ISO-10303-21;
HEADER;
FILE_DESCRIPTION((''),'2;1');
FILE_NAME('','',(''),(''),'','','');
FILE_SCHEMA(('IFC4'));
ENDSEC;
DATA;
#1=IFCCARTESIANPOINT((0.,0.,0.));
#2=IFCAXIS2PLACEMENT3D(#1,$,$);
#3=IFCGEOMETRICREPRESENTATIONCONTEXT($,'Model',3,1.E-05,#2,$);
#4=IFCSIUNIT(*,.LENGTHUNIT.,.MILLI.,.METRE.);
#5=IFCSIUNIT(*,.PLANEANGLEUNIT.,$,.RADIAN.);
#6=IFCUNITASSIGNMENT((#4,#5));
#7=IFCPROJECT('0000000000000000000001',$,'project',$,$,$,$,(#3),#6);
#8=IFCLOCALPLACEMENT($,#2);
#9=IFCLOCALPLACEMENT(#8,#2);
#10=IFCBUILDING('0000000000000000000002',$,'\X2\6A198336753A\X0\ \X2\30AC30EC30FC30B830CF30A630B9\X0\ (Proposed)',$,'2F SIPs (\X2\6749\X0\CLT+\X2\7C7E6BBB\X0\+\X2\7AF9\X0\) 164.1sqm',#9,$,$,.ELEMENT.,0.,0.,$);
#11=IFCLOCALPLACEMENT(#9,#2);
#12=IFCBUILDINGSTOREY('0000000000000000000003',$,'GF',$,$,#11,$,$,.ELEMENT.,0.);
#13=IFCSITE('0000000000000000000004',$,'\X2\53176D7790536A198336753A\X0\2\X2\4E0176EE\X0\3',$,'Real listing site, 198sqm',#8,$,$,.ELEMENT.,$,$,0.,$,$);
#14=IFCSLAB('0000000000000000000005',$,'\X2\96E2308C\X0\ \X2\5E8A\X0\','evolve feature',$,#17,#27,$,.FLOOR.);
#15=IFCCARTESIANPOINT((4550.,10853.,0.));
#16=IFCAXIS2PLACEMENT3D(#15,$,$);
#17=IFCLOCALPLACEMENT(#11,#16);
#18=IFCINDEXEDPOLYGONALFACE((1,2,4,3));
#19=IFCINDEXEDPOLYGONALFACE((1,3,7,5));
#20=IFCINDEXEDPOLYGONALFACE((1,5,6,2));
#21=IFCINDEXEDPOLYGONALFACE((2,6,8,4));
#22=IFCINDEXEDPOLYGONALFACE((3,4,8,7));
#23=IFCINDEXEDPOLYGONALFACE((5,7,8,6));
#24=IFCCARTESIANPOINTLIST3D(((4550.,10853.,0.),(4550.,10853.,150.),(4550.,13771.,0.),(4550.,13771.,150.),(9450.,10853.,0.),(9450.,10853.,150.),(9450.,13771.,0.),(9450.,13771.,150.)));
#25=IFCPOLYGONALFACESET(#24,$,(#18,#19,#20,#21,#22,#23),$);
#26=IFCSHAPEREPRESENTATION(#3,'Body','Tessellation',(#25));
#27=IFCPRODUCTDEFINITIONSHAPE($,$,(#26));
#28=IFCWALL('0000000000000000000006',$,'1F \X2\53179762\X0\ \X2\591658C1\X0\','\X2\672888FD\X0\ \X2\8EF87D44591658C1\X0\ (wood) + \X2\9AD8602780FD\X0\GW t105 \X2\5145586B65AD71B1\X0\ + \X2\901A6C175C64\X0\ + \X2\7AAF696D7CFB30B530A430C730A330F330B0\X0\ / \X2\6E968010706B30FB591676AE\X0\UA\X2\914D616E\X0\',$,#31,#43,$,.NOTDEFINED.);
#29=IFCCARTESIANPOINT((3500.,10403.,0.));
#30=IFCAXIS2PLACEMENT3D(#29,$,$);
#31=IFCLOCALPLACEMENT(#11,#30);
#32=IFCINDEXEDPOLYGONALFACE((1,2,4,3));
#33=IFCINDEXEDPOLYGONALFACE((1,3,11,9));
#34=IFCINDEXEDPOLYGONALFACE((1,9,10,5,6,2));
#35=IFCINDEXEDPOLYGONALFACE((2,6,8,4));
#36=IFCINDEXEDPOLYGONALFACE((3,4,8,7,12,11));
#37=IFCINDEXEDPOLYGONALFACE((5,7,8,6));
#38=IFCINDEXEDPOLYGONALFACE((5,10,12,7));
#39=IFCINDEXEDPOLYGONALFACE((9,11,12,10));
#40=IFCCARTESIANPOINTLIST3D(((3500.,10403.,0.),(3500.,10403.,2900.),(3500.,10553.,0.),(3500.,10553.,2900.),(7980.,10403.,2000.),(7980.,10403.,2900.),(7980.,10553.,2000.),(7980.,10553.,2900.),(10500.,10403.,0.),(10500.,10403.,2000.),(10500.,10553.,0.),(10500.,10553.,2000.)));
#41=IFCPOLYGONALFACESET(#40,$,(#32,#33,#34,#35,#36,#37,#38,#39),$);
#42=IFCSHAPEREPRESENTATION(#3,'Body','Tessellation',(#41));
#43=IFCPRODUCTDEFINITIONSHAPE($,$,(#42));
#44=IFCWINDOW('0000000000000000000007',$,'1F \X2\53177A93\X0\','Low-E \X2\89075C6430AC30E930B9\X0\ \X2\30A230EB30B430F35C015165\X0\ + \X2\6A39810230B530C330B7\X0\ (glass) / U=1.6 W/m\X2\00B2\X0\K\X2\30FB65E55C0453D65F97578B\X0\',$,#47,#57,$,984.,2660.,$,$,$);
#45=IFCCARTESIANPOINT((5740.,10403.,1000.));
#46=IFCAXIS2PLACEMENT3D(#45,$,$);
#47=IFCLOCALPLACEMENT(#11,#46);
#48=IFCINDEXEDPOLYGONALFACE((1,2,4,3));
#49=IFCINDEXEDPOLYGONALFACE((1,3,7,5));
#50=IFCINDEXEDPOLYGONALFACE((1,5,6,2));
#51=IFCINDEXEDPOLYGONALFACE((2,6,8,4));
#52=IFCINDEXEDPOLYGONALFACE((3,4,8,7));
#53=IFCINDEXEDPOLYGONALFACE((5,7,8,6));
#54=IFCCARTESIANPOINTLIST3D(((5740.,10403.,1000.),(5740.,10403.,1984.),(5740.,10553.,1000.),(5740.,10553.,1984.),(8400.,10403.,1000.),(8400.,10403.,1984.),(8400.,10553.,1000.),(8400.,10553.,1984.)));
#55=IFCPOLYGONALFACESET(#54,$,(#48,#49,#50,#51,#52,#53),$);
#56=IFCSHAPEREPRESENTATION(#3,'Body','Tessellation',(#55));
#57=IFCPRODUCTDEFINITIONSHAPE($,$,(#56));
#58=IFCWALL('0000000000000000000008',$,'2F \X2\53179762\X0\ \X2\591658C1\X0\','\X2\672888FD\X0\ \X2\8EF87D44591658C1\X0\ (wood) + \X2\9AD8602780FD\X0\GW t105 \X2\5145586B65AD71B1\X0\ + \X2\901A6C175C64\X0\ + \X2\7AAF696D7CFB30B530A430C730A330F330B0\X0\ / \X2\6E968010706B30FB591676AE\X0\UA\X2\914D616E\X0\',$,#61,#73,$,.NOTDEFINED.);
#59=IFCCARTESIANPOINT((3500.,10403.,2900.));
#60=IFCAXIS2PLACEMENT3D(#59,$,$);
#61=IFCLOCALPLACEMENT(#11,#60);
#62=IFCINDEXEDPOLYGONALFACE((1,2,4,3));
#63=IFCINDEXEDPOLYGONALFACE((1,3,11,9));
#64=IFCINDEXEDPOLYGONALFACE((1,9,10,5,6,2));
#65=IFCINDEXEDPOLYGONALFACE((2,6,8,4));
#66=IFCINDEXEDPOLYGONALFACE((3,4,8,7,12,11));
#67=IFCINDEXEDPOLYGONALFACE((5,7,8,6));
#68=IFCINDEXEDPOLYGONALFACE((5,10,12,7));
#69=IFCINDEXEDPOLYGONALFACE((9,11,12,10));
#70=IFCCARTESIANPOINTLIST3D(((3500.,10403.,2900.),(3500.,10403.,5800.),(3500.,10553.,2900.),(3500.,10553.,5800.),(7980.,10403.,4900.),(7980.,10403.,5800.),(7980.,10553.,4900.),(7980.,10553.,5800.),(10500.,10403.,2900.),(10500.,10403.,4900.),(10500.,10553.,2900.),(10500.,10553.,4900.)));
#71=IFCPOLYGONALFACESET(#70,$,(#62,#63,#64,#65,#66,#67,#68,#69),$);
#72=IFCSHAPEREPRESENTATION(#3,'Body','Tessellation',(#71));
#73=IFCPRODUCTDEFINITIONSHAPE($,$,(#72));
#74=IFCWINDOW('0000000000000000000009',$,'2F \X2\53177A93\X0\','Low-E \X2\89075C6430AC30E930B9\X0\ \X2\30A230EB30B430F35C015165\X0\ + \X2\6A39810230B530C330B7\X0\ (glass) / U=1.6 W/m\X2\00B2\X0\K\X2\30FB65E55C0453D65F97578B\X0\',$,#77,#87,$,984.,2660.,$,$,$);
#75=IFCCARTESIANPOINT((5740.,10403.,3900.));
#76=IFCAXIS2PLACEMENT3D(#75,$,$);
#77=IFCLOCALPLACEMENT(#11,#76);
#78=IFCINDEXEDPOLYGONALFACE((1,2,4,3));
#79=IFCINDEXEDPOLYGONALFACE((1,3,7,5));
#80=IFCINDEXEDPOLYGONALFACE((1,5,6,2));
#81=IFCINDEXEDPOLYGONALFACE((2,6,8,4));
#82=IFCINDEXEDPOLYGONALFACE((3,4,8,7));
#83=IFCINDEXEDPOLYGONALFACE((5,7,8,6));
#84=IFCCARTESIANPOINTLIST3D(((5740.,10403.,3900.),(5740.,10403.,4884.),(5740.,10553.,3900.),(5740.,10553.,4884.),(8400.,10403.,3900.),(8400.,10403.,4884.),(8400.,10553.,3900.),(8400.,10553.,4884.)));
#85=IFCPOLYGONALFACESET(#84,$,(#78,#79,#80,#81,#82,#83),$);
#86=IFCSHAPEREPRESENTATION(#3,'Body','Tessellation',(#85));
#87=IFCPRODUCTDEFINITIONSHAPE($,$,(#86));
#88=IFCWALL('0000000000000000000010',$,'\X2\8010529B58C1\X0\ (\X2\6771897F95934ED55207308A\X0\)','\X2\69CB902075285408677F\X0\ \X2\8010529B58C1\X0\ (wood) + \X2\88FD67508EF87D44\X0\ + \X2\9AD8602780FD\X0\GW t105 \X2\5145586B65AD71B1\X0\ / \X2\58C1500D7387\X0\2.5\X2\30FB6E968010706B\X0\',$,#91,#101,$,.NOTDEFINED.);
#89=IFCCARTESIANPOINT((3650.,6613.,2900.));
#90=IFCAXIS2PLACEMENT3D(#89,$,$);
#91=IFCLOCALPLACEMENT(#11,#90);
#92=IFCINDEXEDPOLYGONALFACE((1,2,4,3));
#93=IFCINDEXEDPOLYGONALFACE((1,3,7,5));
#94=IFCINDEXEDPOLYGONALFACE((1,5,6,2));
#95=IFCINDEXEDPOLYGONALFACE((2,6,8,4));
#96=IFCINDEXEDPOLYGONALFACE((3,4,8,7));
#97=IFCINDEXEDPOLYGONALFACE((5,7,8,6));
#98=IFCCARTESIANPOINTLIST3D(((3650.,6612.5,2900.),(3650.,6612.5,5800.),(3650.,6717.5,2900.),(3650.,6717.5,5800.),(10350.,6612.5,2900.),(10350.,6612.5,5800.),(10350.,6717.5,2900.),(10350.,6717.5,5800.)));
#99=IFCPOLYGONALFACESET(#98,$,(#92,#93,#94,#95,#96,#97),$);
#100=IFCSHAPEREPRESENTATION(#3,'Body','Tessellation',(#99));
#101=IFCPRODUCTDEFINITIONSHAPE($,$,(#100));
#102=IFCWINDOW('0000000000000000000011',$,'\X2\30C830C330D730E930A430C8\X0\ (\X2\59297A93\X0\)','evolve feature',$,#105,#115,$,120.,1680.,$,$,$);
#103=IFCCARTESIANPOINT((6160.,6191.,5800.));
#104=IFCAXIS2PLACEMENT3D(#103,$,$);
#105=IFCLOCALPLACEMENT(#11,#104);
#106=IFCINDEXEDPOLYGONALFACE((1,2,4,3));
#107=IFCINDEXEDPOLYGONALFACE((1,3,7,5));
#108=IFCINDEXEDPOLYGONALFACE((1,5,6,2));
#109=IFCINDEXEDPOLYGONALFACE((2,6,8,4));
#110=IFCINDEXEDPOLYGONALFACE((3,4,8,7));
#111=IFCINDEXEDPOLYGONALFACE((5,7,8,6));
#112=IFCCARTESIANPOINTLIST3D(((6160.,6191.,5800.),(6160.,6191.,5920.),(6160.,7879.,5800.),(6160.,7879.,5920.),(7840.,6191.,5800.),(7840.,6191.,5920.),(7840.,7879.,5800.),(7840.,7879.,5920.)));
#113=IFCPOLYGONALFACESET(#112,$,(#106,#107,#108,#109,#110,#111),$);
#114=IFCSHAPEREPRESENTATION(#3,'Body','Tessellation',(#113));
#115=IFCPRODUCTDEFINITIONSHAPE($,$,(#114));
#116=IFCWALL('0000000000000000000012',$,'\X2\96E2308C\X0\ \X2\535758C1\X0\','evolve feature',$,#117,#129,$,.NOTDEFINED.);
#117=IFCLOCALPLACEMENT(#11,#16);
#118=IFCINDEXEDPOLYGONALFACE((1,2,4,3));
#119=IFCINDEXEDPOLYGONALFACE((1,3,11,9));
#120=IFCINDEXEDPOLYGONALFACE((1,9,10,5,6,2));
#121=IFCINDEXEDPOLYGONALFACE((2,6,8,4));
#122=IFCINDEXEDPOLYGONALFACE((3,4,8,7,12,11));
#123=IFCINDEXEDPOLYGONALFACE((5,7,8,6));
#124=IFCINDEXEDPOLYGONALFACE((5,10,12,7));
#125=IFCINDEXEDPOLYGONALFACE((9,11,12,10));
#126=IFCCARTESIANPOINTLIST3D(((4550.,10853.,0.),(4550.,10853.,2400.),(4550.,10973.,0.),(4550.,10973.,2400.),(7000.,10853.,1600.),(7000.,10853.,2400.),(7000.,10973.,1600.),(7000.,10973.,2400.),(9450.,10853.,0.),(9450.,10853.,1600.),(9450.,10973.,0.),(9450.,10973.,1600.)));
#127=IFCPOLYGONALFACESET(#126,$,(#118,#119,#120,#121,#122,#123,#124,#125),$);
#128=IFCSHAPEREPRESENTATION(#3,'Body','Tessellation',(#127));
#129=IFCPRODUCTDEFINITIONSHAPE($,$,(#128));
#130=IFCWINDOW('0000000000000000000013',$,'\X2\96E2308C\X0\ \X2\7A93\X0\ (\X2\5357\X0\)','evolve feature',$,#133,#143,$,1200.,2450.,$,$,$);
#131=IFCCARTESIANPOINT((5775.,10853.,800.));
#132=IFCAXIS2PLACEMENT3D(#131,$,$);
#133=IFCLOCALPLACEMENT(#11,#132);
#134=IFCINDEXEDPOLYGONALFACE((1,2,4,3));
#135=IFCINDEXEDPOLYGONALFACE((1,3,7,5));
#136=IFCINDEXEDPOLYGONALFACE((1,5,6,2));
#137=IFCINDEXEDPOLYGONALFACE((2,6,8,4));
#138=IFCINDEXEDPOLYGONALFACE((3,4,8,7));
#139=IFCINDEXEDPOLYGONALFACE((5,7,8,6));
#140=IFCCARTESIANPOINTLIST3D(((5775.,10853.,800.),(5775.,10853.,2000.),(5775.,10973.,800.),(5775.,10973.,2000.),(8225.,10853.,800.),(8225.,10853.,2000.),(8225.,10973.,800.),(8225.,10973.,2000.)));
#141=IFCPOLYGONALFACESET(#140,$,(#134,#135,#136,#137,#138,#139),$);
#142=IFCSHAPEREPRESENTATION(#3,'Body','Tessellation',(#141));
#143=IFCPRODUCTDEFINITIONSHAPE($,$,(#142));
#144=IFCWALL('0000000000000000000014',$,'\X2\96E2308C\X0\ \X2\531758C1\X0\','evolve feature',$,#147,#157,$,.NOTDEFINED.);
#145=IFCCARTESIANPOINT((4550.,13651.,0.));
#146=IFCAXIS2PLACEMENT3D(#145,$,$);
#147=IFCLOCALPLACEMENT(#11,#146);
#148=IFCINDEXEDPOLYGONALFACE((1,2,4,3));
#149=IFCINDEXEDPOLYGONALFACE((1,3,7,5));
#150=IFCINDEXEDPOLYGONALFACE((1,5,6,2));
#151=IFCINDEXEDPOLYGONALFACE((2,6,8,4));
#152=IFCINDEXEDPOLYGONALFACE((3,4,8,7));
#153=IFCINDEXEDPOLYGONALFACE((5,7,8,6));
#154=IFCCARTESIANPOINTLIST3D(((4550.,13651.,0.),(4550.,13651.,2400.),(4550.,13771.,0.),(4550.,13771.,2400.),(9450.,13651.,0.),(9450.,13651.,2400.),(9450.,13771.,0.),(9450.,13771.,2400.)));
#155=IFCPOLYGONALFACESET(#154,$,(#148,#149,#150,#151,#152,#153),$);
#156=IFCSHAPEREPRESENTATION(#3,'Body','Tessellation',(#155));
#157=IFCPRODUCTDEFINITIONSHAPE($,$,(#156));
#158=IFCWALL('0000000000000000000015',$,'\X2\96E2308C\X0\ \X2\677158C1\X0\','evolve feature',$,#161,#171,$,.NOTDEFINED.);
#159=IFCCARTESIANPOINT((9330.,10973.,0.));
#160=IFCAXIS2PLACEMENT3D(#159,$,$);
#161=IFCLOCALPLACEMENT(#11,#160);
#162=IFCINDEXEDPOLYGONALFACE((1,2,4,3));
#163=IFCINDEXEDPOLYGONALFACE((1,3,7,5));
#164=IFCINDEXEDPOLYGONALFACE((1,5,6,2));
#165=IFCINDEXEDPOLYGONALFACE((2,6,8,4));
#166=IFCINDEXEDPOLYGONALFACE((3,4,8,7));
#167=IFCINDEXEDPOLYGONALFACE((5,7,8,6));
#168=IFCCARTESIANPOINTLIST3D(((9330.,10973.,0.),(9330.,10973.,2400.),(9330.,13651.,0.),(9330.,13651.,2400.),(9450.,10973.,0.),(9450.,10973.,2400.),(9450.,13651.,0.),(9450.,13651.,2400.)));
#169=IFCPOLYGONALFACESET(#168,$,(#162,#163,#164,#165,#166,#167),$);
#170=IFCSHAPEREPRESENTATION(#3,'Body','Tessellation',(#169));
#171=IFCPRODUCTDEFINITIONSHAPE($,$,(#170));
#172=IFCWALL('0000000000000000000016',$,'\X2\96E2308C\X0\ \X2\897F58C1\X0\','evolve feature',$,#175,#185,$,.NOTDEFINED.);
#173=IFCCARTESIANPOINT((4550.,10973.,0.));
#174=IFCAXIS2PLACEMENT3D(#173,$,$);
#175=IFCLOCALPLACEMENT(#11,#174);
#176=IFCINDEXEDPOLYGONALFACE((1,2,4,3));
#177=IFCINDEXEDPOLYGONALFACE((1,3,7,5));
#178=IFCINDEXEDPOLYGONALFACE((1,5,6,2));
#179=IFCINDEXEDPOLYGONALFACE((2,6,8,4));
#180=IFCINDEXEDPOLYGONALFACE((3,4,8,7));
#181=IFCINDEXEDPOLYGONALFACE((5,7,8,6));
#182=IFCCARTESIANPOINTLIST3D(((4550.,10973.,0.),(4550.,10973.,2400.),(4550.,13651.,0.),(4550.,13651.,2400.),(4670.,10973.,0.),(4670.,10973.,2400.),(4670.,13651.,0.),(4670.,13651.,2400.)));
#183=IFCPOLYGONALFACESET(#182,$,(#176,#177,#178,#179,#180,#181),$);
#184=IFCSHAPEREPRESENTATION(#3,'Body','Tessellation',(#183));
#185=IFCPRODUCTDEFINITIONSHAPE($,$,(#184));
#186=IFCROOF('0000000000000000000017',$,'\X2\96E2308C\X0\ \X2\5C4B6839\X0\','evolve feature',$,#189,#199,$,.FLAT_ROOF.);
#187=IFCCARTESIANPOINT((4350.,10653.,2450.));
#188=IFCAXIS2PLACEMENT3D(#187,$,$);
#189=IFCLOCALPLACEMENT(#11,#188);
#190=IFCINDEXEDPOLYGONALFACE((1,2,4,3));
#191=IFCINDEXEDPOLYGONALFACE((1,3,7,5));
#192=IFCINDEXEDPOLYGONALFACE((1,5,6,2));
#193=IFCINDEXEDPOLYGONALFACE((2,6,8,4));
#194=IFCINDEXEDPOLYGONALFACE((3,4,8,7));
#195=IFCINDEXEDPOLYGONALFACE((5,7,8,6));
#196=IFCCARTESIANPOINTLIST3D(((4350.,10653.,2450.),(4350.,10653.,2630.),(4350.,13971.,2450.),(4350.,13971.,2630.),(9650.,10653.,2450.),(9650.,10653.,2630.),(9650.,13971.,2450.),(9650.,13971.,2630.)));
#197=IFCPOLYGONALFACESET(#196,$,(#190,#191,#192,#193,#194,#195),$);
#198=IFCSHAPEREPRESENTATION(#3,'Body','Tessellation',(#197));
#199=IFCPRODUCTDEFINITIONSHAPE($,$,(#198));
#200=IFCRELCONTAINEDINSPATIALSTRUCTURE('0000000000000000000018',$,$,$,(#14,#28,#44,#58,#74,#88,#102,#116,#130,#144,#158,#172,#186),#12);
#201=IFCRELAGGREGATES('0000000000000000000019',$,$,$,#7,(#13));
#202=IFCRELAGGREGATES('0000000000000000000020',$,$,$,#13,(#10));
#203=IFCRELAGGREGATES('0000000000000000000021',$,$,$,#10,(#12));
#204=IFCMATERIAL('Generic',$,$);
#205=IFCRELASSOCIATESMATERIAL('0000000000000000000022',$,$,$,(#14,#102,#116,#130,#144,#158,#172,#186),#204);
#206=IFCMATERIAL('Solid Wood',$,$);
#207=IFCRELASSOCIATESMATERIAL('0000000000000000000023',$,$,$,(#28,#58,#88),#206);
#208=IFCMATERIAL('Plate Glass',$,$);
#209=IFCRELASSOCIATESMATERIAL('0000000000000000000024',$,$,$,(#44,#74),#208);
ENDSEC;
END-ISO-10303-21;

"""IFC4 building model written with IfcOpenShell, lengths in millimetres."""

from ifc_helpers import new_model, si_unit, frame, frame_2d, origin, place, context, project, spatial, rectangle, extrude, material, element, fill, save


model = new_model("IFC4")

# Units and contexts
model_context = context("Model", 3, precision=1e-05, world=origin())
ifc_project = project(units=[si_unit("LENGTHUNIT", "METRE", prefix="MILLI"), si_unit("PLANEANGLEUNIT", "RADIAN")], contexts=[model_context])

# Site, building, storey
site_placement = place(None, origin())
site = spatial("IfcSite", under=ifc_project, at=site_placement, Name="北海道標茶町2丁目3", ObjectType="Real listing site, 198sqm", CompositionType="ELEMENT", RefElevation=0.0)
building_placement = place(site_placement, origin())
building = spatial("IfcBuilding", under=site, at=building_placement, Name="標茶町 ガレージハウス (Proposed)", ObjectType="2F SIPs (杉CLT+籾殻+竹) 164.1sqm", CompositionType="ELEMENT", ElevationOfRefHeight=0.0, ElevationOfTerrain=0.0)
storey_placement = place(building_placement, origin())
storey = spatial("IfcBuildingStorey", under=building, at=storey_placement, Name="GF", CompositionType="ELEMENT", Elevation=0.0)

# Slab
ifc_material_1 = material(Name="Generic")
slab_placement = place(storey_placement, frame((4550.0, 10853.0, 0.0)))
element("IfcSlab", 1, at=slab_placement, inside=storey, material=ifc_material_1, Name="離れ 床", Description="evolve feature", PredefinedType="FLOOR", context=model_context, shape_type="SweptSolid", body=[
    extrude(rectangle(XDim=4900.0, YDim=2918.0, at=frame_2d((2450.0, 1459.0))), frame((4550.0, 10853.0, 0.0)), (0.0, 0.0, 1.0), 150.0),
])

# Wall, opening, window
ifc_material_2 = material(Name="Solid Wood")
wall_1_placement = place(storey_placement, frame((3500.0, 10403.0, 0.0)))
wall_1 = element("IfcWall", 2, at=wall_1_placement, inside=storey, material=ifc_material_2, Name="1F 北面 外壁", Description="木製 軸組外壁 (wood) + 高性能GW t105 充填断熱 + 通気層 + 窯業系サイディング / 準耐火・外皮UA配慮", PredefinedType="NOTDEFINED", context=model_context, shape_type="SweptSolid", body=[
    extrude(rectangle(XDim=7000.0, YDim=150.0, at=frame_2d((3500.0, 75.0))), frame((3500.0, 10403.0, 0.0)), (0.0, 0.0, 1.0), 2900.0),
])
opening_1_placement = place(storey_placement, frame((5740.0, 10403.0, 1000.0)))
opening_1 = element("IfcOpeningElement", 3, at=opening_1_placement, cuts=wall_1, PredefinedType="NOTDEFINED", context=model_context, shape_type="SweptSolid", body=[
    extrude(rectangle(XDim=2660.0, YDim=150.0, at=frame_2d((1330.0, 75.0))), frame((5740.0, 10403.0, 1000.0)), (0.0, 0.0, 1.0), 984.0),
])
ifc_material_3 = material(Name="Plate Glass")
window_1_placement = place(storey_placement, frame((5740.0, 10403.0, 1000.0)))
window_1 = element("IfcWindow", 4, at=window_1_placement, inside=storey, material=ifc_material_3, Name="1F 北窓", Description="Low-E 複層ガラス アルゴン封入 + 樹脂サッシ (glass) / U=1.6 W/m²K・日射取得型", OverallHeight=984.0, OverallWidth=2660.0, context=model_context, shape_type="SweptSolid", body=[
    extrude(rectangle(XDim=2660.0, YDim=150.0, at=frame_2d((1330.0, 75.0))), frame((5740.0, 10403.0, 1000.0)), (0.0, 0.0, 1.0), 984.0),
])
fill(opening_1, window_1)

# Wall, opening, window
wall_2_placement = place(storey_placement, frame((3500.0, 10403.0, 2900.0)))
wall_2 = element("IfcWall", 5, at=wall_2_placement, inside=storey, material=ifc_material_2, Name="2F 北面 外壁", Description="木製 軸組外壁 (wood) + 高性能GW t105 充填断熱 + 通気層 + 窯業系サイディング / 準耐火・外皮UA配慮", PredefinedType="NOTDEFINED", context=model_context, shape_type="SweptSolid", body=[
    extrude(rectangle(XDim=7000.0, YDim=150.0, at=frame_2d((3500.0, 75.0))), frame((3500.0, 10403.0, 2900.0)), (0.0, 0.0, 1.0), 2900.0),
])
opening_2_placement = place(storey_placement, frame((5740.0, 10403.0, 3900.0)))
opening_2 = element("IfcOpeningElement", 6, at=opening_2_placement, cuts=wall_2, PredefinedType="NOTDEFINED", context=model_context, shape_type="SweptSolid", body=[
    extrude(rectangle(XDim=2660.0, YDim=150.0, at=frame_2d((1330.0, 75.0))), frame((5740.0, 10403.0, 3900.0)), (0.0, 0.0, 1.0), 984.0),
])
window_2_placement = place(storey_placement, frame((5740.0, 10403.0, 3900.0)))
window_2 = element("IfcWindow", 7, at=window_2_placement, inside=storey, material=ifc_material_3, Name="2F 北窓", Description="Low-E 複層ガラス アルゴン封入 + 樹脂サッシ (glass) / U=1.6 W/m²K・日射取得型", OverallHeight=984.0, OverallWidth=2660.0, context=model_context, shape_type="SweptSolid", body=[
    extrude(rectangle(XDim=2660.0, YDim=150.0, at=frame_2d((1330.0, 75.0))), frame((5740.0, 10403.0, 3900.0)), (0.0, 0.0, 1.0), 984.0),
])
fill(opening_2, window_2)

# Wall
wall_3_placement = place(storey_placement, frame((3650.0, 6613.0, 2900.0)))
element("IfcWall", 8, at=wall_3_placement, inside=storey, material=ifc_material_2, Name="耐力壁 (東西間仕切り)", Description="構造用合板 耐力壁 (wood) + 製材軸組 + 高性能GW t105 充填断熱 / 壁倍率2.5・準耐火", PredefinedType="NOTDEFINED", context=model_context, shape_type="SweptSolid", body=[
    extrude(rectangle(XDim=6700.0, YDim=105.0, at=frame_2d((3350.0, 52.0))), frame((3650.0, 6613.0, 2900.0)), (0.0, 0.0, 1.0), 2900.0),
])

# Window
window_3_placement = place(storey_placement, frame((6160.0, 6191.0, 5800.0)))
element("IfcWindow", 9, at=window_3_placement, inside=storey, material=ifc_material_1, Name="トップライト (天窓)", Description="evolve feature", OverallHeight=120.0, OverallWidth=1680.0, context=model_context, shape_type="SweptSolid", body=[
    extrude(rectangle(XDim=1680.0, YDim=1688.0, at=frame_2d((840.0, 844.0))), frame((6160.0, 6191.0, 5800.0)), (0.0, 0.0, 1.0), 120.0),
])

# Wall, opening, window
wall_4_placement = place(storey_placement, frame((4550.0, 10853.0, 0.0)))
wall_4 = element("IfcWall", 10, at=wall_4_placement, inside=storey, material=ifc_material_1, Name="離れ 南壁", Description="evolve feature", PredefinedType="NOTDEFINED", context=model_context, shape_type="SweptSolid", body=[
    extrude(rectangle(XDim=4900.0, YDim=120.0, at=frame_2d((2450.0, 60.0))), frame((4550.0, 10853.0, 0.0)), (0.0, 0.0, 1.0), 2400.0),
])
opening_3_placement = place(storey_placement, frame((5775.0, 10853.0, 800.0)))
opening_3 = element("IfcOpeningElement", 11, at=opening_3_placement, cuts=wall_4, PredefinedType="NOTDEFINED", context=model_context, shape_type="SweptSolid", body=[
    extrude(rectangle(XDim=2450.0, YDim=120.0, at=frame_2d((1225.0, 60.0))), frame((5775.0, 10853.0, 800.0)), (0.0, 0.0, 1.0), 1200.0),
])
window_4_placement = place(storey_placement, frame((5775.0, 10853.0, 800.0)))
window_4 = element("IfcWindow", 12, at=window_4_placement, inside=storey, material=ifc_material_1, Name="離れ 窓 (南)", Description="evolve feature", OverallHeight=1200.0, OverallWidth=2450.0, context=model_context, shape_type="SweptSolid", body=[
    extrude(rectangle(XDim=2450.0, YDim=120.0, at=frame_2d((1225.0, 60.0))), frame((5775.0, 10853.0, 800.0)), (0.0, 0.0, 1.0), 1200.0),
])
fill(opening_3, window_4)

# Walls
wall_5_placement = place(storey_placement, frame((4550.0, 13651.0, 0.0)))
element("IfcWall", 13, at=wall_5_placement, inside=storey, material=ifc_material_1, Name="離れ 北壁", Description="evolve feature", PredefinedType="NOTDEFINED", context=model_context, shape_type="SweptSolid", body=[
    extrude(rectangle(XDim=4900.0, YDim=120.0, at=frame_2d((2450.0, 60.0))), frame((4550.0, 13651.0, 0.0)), (0.0, 0.0, 1.0), 2400.0),
])
wall_6_placement = place(storey_placement, frame((9330.0, 10973.0, 0.0)))
element("IfcWall", 14, at=wall_6_placement, inside=storey, material=ifc_material_1, Name="離れ 東壁", Description="evolve feature", PredefinedType="NOTDEFINED", context=model_context, shape_type="SweptSolid", body=[
    extrude(rectangle(XDim=120.0, YDim=2678.0, at=frame_2d((60.0, 1339.0))), frame((9330.0, 10973.0, 0.0)), (0.0, 0.0, 1.0), 2400.0),
])
wall_7_placement = place(storey_placement, frame((4550.0, 10973.0, 0.0)))
element("IfcWall", 15, at=wall_7_placement, inside=storey, material=ifc_material_1, Name="離れ 西壁", Description="evolve feature", PredefinedType="NOTDEFINED", context=model_context, shape_type="SweptSolid", body=[
    extrude(rectangle(XDim=120.0, YDim=2678.0, at=frame_2d((60.0, 1339.0))), frame((4550.0, 10973.0, 0.0)), (0.0, 0.0, 1.0), 2400.0),
])

# Roof
roof_placement = place(storey_placement, frame((4350.0, 10653.0, 2450.0)))
element("IfcRoof", 16, at=roof_placement, inside=storey, material=ifc_material_1, Name="離れ 屋根", Description="evolve feature", PredefinedType="FLAT_ROOF", context=model_context, shape_type="SweptSolid", body=[
    extrude(rectangle(XDim=5300.0, YDim=3318.0, at=frame_2d((2650.0, 1659.0))), frame((4350.0, 10653.0, 2450.0)), (0.0, 0.0, 1.0), 180.0),
])

save(model, "model.ifc")
